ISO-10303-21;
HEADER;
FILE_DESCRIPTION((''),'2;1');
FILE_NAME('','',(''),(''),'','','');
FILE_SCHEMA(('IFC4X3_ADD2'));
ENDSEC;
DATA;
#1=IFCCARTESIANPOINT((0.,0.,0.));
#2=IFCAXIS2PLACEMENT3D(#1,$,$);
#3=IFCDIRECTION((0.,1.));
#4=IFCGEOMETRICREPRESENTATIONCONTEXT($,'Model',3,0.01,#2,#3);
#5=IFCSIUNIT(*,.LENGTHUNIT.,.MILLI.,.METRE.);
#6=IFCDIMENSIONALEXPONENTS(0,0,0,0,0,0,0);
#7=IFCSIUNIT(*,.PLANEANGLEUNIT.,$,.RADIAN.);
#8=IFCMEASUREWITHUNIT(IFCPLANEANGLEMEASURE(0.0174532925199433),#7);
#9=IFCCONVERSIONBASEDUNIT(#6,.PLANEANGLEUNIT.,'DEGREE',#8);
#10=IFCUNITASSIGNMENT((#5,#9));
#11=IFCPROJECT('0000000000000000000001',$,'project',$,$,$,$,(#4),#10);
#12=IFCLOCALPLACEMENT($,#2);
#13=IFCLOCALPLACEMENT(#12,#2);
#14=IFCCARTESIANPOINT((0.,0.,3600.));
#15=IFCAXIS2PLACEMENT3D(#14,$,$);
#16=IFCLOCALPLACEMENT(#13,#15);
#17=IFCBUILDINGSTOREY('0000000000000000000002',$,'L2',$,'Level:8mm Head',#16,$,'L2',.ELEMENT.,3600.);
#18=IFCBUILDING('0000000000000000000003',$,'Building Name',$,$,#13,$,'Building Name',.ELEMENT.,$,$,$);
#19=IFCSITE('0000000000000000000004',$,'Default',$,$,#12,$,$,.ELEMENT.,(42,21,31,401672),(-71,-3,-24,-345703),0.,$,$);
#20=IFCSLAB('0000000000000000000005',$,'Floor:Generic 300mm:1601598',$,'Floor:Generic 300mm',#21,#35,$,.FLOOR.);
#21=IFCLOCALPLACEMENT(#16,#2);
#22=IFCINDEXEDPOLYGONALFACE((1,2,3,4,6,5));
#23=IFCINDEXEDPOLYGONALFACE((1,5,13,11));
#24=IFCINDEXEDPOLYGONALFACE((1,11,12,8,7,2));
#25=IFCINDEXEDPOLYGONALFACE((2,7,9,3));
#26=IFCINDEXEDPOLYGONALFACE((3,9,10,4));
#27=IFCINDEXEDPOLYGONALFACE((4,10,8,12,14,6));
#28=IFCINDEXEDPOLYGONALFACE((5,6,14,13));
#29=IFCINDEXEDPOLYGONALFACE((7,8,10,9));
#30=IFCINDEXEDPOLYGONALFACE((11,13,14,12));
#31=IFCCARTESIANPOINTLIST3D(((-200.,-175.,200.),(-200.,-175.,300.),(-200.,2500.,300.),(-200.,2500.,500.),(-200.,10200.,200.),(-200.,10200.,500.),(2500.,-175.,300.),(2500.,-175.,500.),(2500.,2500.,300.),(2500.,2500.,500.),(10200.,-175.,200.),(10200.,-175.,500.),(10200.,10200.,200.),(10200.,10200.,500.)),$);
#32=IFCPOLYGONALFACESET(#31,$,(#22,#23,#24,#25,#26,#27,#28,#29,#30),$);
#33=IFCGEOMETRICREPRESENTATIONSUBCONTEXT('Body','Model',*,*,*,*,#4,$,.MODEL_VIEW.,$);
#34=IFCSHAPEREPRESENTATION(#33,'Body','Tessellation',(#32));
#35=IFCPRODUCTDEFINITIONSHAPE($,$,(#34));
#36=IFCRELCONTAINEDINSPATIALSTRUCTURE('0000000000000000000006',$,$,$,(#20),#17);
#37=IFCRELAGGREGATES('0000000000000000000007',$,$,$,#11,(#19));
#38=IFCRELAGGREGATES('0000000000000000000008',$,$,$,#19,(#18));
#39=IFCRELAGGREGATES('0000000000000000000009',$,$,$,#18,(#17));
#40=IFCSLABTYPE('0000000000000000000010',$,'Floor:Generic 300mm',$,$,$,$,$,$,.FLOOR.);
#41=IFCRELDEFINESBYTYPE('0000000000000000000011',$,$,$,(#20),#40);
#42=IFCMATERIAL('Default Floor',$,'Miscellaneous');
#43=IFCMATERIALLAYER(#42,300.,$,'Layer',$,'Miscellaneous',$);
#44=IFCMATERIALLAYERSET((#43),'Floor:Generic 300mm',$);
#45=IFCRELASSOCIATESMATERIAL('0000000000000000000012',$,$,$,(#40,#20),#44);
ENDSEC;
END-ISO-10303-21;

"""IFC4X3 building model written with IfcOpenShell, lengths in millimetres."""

from ifc_helpers import new_model, entity, si_unit, converted_unit, direction, frame, frame_2d, origin, place, context, subcontext, project, spatial, rectangle, extrude, material, layer, layer_set, layer_usage, type_object, element, save


model = new_model("IFC4X3")

# Units and contexts
model_context = context("Model", 3, precision=0.01, world=origin(), true_north=direction((0.0, 1.0)))
body_context = subcontext(model_context, "Body", "Model", "MODEL_VIEW")
ifc_project = project(units=[si_unit("LENGTHUNIT", "METRE", prefix="MILLI"), converted_unit("PLANEANGLEUNIT", "DEGREE", entity("IfcPlaneAngleMeasure", 0.0174532925199433), si_unit("PLANEANGLEUNIT", "RADIAN"), dimensions=[0, 0, 0, 0, 0, 0, 0])], contexts=[model_context])

# Site, building, storey
site_placement = place(None, origin())
site = spatial("IfcSite", under=ifc_project, at=site_placement, Name="Default", CompositionType="ELEMENT", RefLatitude=(42, 21, 31, 401672), RefLongitude=(-71, -3, -24, -345703), RefElevation=0.0)
building_placement = place(site_placement, origin())
building = spatial("IfcBuilding", under=site, at=building_placement, Name="Building Name", LongName="Building Name", CompositionType="ELEMENT")
storey_placement = place(building_placement, frame((0.0, 0.0, 3600.0)))
storey = spatial("IfcBuildingStorey", under=building, at=storey_placement, Name="L2", ObjectType="Level:8mm Head", LongName="L2", CompositionType="ELEMENT", Elevation=3600.0)

# Slab, opening
ifc_material = material(Name="Default Floor", Category="Miscellaneous")
ifc_layer = layer(ifc_material, 300.0, Name="Layer", Category="Miscellaneous")
ifc_layer_set = layer_set([ifc_layer], Name="Floor:Generic 300mm")
ifc_layer_usage = layer_usage(ifc_layer_set, "AXIS3", "POSITIVE", 0.0)
slab_type = type_object("IfcSlabType", Name="Floor:Generic 300mm", PredefinedType="FLOOR", material=ifc_layer_set)
placement = place(storey_placement, origin())
slab = element("IfcSlab", 1, at=placement, inside=storey, type_object=slab_type, material=ifc_layer_usage, Name="Floor:Generic 300mm:1601598", ObjectType="Floor:Generic 300mm", PredefinedType="FLOOR", context=body_context, shape_type="SweptSolid", body=[
    extrude(rectangle(XDim=10375.0, YDim=10400.0, at=frame_2d((0.0, 0.0), x_axis=(1.0, 0.0))), frame((5000.0, 5012.5, 500.0), z_axis=(0.0, 0.0, -1.0), x_axis=(0.0, 1.0, 0.0)), (0.0, 0.0, 1.0), 300.0),
])
element("IfcOpeningElement", 2, at=placement, inside=storey, cuts=slab, context=body_context, shape_type="SweptSolid", body=[
    extrude(rectangle(XDim=5000.0, YDim=5000.0), frame((0.0, 0.0, 300.0), z_axis=(0.0, 0.0, 1.0), x_axis=(1.0, 0.0, 0.0)), (0.0, 0.0, 1.0), 300.0),
])

save(model, "model.ifc")
